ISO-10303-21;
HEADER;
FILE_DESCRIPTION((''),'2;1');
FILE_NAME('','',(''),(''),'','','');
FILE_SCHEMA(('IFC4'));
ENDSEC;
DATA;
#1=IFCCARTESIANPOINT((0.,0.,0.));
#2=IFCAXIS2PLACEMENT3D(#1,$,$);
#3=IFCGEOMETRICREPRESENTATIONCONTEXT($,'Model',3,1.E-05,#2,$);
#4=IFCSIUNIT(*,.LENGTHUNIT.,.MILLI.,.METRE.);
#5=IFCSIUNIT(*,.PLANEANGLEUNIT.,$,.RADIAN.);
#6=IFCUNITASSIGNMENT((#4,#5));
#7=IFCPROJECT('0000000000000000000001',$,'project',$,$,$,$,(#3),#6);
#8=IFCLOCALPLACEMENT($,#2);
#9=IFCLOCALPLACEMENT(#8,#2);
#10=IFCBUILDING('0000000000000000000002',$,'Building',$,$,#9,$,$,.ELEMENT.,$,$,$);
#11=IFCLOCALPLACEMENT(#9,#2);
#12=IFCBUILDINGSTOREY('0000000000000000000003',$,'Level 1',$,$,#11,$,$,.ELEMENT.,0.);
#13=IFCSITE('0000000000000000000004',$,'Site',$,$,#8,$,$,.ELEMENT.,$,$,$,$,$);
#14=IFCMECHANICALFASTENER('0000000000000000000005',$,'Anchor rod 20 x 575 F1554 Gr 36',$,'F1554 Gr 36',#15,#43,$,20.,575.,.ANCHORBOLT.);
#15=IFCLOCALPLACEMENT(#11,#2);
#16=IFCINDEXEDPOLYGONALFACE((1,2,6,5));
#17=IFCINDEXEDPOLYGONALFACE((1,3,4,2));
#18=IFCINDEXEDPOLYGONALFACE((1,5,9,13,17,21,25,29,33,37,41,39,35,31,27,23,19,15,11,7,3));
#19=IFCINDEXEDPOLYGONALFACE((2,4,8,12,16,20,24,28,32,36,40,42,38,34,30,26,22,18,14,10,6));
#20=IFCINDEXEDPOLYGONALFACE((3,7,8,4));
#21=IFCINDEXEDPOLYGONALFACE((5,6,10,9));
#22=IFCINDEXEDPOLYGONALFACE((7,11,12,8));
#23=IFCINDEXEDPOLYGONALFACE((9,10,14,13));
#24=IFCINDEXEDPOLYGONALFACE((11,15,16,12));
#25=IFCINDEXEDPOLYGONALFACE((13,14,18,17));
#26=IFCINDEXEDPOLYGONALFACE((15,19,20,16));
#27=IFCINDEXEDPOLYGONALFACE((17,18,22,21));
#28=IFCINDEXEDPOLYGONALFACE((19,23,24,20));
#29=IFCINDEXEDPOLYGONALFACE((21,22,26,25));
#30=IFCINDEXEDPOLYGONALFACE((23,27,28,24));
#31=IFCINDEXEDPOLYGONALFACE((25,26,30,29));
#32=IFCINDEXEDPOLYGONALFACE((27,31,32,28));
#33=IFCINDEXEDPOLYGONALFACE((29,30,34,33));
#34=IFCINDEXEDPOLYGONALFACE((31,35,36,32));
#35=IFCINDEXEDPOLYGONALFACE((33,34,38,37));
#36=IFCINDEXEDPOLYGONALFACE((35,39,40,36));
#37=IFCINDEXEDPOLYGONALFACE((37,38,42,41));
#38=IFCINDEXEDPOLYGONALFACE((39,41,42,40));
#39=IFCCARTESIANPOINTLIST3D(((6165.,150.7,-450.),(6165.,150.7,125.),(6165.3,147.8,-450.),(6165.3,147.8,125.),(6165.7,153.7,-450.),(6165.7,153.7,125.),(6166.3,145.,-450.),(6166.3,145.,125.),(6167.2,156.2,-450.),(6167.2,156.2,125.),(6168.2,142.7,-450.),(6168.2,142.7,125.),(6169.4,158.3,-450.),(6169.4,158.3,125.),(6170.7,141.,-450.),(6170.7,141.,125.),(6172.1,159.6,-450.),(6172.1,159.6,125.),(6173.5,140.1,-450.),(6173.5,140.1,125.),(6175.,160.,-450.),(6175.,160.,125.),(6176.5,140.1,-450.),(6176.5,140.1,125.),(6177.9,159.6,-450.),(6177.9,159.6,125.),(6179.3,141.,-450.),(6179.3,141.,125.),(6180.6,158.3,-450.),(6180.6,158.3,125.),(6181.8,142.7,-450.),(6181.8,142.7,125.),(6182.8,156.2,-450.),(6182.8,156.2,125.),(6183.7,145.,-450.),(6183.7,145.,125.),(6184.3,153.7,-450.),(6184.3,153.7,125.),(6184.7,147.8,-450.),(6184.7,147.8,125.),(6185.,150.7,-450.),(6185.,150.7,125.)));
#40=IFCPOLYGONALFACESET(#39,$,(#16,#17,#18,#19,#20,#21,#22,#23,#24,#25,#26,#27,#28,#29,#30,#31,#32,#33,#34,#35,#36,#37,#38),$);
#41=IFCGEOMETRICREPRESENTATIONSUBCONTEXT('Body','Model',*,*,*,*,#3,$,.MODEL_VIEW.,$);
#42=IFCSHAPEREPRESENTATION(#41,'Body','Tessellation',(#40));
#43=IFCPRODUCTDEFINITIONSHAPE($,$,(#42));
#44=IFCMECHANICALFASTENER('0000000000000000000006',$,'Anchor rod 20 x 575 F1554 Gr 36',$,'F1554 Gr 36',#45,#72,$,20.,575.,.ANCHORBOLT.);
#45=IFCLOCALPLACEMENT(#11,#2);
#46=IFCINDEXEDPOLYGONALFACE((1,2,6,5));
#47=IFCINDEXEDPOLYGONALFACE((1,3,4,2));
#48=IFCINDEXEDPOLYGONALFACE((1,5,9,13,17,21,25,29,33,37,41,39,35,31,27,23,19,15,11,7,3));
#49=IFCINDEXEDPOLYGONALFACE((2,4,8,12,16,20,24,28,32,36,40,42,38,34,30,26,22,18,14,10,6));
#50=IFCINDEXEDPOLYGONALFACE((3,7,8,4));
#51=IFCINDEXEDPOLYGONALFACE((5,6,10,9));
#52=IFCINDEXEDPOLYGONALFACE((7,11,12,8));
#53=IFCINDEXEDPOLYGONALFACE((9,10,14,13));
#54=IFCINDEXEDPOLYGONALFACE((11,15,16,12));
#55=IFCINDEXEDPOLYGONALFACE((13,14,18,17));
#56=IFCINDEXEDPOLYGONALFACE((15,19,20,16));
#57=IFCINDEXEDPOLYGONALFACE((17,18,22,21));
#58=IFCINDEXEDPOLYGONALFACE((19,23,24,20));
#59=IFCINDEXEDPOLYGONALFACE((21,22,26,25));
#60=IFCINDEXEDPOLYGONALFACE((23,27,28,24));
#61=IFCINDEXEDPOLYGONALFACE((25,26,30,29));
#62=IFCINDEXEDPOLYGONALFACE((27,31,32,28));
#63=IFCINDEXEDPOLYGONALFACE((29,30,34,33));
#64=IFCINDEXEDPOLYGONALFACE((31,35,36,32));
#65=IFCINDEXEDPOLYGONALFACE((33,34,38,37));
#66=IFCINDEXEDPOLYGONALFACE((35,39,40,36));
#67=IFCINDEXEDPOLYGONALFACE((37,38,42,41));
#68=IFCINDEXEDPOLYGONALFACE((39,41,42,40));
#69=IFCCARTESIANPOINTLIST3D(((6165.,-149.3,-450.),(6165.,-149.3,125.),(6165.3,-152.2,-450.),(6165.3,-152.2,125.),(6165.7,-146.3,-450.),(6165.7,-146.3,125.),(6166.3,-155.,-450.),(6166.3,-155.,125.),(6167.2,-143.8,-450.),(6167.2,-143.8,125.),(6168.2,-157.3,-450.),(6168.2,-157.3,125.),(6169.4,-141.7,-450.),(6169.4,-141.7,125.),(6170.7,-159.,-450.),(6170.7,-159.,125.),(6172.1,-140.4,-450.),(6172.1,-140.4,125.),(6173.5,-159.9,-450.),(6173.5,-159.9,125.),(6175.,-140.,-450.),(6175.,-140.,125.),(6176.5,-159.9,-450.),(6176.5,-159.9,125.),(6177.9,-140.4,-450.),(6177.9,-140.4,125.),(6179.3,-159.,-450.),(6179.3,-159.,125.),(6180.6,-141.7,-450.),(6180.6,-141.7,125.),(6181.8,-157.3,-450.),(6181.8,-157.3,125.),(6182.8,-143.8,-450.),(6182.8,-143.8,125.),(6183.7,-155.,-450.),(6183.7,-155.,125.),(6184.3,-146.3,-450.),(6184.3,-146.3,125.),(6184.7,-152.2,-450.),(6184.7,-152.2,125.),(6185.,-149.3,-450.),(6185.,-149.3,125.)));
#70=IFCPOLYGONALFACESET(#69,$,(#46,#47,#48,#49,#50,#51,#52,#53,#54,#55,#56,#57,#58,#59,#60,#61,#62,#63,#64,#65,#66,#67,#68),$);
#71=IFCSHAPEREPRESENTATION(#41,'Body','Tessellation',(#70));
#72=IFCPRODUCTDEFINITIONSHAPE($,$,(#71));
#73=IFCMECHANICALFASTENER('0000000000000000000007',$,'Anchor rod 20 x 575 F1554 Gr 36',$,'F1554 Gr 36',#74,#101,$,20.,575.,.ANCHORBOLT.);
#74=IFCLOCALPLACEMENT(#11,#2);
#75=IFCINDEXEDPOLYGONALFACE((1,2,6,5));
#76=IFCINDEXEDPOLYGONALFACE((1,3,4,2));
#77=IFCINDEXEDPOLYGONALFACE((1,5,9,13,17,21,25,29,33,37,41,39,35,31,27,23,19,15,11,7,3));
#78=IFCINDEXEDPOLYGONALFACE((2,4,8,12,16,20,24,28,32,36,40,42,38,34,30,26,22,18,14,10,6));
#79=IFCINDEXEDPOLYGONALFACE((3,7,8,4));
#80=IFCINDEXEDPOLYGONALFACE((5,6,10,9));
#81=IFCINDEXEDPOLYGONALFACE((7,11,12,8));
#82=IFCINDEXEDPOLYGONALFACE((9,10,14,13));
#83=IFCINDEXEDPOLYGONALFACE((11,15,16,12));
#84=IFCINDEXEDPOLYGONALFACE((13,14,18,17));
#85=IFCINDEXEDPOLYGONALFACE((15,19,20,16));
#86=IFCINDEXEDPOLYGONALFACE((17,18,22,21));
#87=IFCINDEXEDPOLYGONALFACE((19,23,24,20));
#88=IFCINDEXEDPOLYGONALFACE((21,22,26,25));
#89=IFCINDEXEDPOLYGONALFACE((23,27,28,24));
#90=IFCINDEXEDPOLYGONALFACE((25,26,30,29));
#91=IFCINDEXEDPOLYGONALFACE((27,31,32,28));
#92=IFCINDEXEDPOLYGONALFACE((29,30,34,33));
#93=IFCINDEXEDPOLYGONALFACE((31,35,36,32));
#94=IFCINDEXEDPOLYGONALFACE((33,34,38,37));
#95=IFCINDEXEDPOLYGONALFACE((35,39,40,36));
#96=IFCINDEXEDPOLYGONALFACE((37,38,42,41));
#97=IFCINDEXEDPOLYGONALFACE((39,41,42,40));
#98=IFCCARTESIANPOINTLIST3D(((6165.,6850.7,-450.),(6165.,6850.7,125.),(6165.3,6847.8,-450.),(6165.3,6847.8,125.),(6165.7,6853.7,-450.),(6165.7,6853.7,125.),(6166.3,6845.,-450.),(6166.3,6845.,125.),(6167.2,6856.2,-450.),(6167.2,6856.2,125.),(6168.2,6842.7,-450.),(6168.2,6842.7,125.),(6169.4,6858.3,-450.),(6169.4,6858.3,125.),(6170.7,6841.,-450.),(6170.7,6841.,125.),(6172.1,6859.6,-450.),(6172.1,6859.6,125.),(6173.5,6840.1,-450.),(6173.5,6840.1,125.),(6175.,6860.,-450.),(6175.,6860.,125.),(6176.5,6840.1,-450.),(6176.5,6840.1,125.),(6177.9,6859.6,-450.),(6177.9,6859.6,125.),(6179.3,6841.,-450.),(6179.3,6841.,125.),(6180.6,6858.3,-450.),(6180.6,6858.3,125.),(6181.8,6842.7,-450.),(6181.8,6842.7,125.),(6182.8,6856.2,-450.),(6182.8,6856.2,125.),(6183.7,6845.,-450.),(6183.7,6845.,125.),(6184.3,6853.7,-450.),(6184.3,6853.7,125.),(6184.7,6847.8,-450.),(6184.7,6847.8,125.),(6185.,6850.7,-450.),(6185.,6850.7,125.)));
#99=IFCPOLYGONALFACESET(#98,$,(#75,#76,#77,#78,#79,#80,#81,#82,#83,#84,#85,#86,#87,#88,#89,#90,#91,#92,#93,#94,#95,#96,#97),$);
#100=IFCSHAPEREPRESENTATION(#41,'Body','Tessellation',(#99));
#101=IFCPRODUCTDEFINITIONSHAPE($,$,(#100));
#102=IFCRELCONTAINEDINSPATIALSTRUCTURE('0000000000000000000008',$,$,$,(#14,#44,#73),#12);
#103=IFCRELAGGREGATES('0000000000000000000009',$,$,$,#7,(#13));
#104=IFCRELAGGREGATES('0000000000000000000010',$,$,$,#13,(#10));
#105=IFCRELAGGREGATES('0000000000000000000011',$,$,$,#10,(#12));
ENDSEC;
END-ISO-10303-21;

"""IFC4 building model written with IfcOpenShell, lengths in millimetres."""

from ifc_helpers import new_model, si_unit, frame, origin, origin_2d, place, context, subcontext, project, spatial, circle, extrude, element, save


model = new_model("IFC4")

# Units and contexts
model_context = context("Model", 3, precision=1e-05, world=origin())
body_context = subcontext(model_context, "Body", "Model", "MODEL_VIEW")
ifc_project = project(units=[si_unit("LENGTHUNIT", "METRE", prefix="MILLI"), si_unit("PLANEANGLEUNIT", "RADIAN")], contexts=[model_context])

# Site, building, storey
site_placement = place(None, origin())
site = spatial("IfcSite", under=ifc_project, at=site_placement, Name="Site", CompositionType="ELEMENT")
building_placement = place(site_placement, origin())
building = spatial("IfcBuilding", under=site, at=building_placement, Name="Building", CompositionType="ELEMENT")
storey_placement = place(building_placement, origin())
storey = spatial("IfcBuildingStorey", under=building, at=storey_placement, Name="Level 1", CompositionType="ELEMENT", Elevation=0.0)

# Mechanical fasteners
for number, where, z_axis, x_axis, name in (
    (1, (6175.0, 150.0, 125.0), (0.0, 0.0, -1.0), (0.0, 1.0, 0.0), "Anchor rod 20 x 575 F1554 Gr 36"),
    (2, (6175.0, -150.0, 125.0), (0.0, 0.0, -1.0), (0.0, 1.0, 0.0), "Anchor rod 20 x 575 F1554 Gr 36"),
    (3, (6175.0, 6850.0, 125.0), (0.0, 0.0, -1.0), (0.0, 1.0, 0.0), "Anchor rod 20 x 575 F1554 Gr 36"),
):
    element("IfcMechanicalFastener", number, at=place(storey_placement, frame(where, z_axis=z_axis, x_axis=x_axis)), inside=storey, Name=name, ObjectType="F1554 Gr 36", NominalDiameter=20.0, NominalLength=575.0, PredefinedType="ANCHORBOLT", context=body_context, shape_type="SweptSolid", body=[
        extrude(circle(Radius=10.0, at=origin_2d()), origin(), (0.0, 0.0, 1.0), 575.0),
    ])

save(model, "model.ifc")
